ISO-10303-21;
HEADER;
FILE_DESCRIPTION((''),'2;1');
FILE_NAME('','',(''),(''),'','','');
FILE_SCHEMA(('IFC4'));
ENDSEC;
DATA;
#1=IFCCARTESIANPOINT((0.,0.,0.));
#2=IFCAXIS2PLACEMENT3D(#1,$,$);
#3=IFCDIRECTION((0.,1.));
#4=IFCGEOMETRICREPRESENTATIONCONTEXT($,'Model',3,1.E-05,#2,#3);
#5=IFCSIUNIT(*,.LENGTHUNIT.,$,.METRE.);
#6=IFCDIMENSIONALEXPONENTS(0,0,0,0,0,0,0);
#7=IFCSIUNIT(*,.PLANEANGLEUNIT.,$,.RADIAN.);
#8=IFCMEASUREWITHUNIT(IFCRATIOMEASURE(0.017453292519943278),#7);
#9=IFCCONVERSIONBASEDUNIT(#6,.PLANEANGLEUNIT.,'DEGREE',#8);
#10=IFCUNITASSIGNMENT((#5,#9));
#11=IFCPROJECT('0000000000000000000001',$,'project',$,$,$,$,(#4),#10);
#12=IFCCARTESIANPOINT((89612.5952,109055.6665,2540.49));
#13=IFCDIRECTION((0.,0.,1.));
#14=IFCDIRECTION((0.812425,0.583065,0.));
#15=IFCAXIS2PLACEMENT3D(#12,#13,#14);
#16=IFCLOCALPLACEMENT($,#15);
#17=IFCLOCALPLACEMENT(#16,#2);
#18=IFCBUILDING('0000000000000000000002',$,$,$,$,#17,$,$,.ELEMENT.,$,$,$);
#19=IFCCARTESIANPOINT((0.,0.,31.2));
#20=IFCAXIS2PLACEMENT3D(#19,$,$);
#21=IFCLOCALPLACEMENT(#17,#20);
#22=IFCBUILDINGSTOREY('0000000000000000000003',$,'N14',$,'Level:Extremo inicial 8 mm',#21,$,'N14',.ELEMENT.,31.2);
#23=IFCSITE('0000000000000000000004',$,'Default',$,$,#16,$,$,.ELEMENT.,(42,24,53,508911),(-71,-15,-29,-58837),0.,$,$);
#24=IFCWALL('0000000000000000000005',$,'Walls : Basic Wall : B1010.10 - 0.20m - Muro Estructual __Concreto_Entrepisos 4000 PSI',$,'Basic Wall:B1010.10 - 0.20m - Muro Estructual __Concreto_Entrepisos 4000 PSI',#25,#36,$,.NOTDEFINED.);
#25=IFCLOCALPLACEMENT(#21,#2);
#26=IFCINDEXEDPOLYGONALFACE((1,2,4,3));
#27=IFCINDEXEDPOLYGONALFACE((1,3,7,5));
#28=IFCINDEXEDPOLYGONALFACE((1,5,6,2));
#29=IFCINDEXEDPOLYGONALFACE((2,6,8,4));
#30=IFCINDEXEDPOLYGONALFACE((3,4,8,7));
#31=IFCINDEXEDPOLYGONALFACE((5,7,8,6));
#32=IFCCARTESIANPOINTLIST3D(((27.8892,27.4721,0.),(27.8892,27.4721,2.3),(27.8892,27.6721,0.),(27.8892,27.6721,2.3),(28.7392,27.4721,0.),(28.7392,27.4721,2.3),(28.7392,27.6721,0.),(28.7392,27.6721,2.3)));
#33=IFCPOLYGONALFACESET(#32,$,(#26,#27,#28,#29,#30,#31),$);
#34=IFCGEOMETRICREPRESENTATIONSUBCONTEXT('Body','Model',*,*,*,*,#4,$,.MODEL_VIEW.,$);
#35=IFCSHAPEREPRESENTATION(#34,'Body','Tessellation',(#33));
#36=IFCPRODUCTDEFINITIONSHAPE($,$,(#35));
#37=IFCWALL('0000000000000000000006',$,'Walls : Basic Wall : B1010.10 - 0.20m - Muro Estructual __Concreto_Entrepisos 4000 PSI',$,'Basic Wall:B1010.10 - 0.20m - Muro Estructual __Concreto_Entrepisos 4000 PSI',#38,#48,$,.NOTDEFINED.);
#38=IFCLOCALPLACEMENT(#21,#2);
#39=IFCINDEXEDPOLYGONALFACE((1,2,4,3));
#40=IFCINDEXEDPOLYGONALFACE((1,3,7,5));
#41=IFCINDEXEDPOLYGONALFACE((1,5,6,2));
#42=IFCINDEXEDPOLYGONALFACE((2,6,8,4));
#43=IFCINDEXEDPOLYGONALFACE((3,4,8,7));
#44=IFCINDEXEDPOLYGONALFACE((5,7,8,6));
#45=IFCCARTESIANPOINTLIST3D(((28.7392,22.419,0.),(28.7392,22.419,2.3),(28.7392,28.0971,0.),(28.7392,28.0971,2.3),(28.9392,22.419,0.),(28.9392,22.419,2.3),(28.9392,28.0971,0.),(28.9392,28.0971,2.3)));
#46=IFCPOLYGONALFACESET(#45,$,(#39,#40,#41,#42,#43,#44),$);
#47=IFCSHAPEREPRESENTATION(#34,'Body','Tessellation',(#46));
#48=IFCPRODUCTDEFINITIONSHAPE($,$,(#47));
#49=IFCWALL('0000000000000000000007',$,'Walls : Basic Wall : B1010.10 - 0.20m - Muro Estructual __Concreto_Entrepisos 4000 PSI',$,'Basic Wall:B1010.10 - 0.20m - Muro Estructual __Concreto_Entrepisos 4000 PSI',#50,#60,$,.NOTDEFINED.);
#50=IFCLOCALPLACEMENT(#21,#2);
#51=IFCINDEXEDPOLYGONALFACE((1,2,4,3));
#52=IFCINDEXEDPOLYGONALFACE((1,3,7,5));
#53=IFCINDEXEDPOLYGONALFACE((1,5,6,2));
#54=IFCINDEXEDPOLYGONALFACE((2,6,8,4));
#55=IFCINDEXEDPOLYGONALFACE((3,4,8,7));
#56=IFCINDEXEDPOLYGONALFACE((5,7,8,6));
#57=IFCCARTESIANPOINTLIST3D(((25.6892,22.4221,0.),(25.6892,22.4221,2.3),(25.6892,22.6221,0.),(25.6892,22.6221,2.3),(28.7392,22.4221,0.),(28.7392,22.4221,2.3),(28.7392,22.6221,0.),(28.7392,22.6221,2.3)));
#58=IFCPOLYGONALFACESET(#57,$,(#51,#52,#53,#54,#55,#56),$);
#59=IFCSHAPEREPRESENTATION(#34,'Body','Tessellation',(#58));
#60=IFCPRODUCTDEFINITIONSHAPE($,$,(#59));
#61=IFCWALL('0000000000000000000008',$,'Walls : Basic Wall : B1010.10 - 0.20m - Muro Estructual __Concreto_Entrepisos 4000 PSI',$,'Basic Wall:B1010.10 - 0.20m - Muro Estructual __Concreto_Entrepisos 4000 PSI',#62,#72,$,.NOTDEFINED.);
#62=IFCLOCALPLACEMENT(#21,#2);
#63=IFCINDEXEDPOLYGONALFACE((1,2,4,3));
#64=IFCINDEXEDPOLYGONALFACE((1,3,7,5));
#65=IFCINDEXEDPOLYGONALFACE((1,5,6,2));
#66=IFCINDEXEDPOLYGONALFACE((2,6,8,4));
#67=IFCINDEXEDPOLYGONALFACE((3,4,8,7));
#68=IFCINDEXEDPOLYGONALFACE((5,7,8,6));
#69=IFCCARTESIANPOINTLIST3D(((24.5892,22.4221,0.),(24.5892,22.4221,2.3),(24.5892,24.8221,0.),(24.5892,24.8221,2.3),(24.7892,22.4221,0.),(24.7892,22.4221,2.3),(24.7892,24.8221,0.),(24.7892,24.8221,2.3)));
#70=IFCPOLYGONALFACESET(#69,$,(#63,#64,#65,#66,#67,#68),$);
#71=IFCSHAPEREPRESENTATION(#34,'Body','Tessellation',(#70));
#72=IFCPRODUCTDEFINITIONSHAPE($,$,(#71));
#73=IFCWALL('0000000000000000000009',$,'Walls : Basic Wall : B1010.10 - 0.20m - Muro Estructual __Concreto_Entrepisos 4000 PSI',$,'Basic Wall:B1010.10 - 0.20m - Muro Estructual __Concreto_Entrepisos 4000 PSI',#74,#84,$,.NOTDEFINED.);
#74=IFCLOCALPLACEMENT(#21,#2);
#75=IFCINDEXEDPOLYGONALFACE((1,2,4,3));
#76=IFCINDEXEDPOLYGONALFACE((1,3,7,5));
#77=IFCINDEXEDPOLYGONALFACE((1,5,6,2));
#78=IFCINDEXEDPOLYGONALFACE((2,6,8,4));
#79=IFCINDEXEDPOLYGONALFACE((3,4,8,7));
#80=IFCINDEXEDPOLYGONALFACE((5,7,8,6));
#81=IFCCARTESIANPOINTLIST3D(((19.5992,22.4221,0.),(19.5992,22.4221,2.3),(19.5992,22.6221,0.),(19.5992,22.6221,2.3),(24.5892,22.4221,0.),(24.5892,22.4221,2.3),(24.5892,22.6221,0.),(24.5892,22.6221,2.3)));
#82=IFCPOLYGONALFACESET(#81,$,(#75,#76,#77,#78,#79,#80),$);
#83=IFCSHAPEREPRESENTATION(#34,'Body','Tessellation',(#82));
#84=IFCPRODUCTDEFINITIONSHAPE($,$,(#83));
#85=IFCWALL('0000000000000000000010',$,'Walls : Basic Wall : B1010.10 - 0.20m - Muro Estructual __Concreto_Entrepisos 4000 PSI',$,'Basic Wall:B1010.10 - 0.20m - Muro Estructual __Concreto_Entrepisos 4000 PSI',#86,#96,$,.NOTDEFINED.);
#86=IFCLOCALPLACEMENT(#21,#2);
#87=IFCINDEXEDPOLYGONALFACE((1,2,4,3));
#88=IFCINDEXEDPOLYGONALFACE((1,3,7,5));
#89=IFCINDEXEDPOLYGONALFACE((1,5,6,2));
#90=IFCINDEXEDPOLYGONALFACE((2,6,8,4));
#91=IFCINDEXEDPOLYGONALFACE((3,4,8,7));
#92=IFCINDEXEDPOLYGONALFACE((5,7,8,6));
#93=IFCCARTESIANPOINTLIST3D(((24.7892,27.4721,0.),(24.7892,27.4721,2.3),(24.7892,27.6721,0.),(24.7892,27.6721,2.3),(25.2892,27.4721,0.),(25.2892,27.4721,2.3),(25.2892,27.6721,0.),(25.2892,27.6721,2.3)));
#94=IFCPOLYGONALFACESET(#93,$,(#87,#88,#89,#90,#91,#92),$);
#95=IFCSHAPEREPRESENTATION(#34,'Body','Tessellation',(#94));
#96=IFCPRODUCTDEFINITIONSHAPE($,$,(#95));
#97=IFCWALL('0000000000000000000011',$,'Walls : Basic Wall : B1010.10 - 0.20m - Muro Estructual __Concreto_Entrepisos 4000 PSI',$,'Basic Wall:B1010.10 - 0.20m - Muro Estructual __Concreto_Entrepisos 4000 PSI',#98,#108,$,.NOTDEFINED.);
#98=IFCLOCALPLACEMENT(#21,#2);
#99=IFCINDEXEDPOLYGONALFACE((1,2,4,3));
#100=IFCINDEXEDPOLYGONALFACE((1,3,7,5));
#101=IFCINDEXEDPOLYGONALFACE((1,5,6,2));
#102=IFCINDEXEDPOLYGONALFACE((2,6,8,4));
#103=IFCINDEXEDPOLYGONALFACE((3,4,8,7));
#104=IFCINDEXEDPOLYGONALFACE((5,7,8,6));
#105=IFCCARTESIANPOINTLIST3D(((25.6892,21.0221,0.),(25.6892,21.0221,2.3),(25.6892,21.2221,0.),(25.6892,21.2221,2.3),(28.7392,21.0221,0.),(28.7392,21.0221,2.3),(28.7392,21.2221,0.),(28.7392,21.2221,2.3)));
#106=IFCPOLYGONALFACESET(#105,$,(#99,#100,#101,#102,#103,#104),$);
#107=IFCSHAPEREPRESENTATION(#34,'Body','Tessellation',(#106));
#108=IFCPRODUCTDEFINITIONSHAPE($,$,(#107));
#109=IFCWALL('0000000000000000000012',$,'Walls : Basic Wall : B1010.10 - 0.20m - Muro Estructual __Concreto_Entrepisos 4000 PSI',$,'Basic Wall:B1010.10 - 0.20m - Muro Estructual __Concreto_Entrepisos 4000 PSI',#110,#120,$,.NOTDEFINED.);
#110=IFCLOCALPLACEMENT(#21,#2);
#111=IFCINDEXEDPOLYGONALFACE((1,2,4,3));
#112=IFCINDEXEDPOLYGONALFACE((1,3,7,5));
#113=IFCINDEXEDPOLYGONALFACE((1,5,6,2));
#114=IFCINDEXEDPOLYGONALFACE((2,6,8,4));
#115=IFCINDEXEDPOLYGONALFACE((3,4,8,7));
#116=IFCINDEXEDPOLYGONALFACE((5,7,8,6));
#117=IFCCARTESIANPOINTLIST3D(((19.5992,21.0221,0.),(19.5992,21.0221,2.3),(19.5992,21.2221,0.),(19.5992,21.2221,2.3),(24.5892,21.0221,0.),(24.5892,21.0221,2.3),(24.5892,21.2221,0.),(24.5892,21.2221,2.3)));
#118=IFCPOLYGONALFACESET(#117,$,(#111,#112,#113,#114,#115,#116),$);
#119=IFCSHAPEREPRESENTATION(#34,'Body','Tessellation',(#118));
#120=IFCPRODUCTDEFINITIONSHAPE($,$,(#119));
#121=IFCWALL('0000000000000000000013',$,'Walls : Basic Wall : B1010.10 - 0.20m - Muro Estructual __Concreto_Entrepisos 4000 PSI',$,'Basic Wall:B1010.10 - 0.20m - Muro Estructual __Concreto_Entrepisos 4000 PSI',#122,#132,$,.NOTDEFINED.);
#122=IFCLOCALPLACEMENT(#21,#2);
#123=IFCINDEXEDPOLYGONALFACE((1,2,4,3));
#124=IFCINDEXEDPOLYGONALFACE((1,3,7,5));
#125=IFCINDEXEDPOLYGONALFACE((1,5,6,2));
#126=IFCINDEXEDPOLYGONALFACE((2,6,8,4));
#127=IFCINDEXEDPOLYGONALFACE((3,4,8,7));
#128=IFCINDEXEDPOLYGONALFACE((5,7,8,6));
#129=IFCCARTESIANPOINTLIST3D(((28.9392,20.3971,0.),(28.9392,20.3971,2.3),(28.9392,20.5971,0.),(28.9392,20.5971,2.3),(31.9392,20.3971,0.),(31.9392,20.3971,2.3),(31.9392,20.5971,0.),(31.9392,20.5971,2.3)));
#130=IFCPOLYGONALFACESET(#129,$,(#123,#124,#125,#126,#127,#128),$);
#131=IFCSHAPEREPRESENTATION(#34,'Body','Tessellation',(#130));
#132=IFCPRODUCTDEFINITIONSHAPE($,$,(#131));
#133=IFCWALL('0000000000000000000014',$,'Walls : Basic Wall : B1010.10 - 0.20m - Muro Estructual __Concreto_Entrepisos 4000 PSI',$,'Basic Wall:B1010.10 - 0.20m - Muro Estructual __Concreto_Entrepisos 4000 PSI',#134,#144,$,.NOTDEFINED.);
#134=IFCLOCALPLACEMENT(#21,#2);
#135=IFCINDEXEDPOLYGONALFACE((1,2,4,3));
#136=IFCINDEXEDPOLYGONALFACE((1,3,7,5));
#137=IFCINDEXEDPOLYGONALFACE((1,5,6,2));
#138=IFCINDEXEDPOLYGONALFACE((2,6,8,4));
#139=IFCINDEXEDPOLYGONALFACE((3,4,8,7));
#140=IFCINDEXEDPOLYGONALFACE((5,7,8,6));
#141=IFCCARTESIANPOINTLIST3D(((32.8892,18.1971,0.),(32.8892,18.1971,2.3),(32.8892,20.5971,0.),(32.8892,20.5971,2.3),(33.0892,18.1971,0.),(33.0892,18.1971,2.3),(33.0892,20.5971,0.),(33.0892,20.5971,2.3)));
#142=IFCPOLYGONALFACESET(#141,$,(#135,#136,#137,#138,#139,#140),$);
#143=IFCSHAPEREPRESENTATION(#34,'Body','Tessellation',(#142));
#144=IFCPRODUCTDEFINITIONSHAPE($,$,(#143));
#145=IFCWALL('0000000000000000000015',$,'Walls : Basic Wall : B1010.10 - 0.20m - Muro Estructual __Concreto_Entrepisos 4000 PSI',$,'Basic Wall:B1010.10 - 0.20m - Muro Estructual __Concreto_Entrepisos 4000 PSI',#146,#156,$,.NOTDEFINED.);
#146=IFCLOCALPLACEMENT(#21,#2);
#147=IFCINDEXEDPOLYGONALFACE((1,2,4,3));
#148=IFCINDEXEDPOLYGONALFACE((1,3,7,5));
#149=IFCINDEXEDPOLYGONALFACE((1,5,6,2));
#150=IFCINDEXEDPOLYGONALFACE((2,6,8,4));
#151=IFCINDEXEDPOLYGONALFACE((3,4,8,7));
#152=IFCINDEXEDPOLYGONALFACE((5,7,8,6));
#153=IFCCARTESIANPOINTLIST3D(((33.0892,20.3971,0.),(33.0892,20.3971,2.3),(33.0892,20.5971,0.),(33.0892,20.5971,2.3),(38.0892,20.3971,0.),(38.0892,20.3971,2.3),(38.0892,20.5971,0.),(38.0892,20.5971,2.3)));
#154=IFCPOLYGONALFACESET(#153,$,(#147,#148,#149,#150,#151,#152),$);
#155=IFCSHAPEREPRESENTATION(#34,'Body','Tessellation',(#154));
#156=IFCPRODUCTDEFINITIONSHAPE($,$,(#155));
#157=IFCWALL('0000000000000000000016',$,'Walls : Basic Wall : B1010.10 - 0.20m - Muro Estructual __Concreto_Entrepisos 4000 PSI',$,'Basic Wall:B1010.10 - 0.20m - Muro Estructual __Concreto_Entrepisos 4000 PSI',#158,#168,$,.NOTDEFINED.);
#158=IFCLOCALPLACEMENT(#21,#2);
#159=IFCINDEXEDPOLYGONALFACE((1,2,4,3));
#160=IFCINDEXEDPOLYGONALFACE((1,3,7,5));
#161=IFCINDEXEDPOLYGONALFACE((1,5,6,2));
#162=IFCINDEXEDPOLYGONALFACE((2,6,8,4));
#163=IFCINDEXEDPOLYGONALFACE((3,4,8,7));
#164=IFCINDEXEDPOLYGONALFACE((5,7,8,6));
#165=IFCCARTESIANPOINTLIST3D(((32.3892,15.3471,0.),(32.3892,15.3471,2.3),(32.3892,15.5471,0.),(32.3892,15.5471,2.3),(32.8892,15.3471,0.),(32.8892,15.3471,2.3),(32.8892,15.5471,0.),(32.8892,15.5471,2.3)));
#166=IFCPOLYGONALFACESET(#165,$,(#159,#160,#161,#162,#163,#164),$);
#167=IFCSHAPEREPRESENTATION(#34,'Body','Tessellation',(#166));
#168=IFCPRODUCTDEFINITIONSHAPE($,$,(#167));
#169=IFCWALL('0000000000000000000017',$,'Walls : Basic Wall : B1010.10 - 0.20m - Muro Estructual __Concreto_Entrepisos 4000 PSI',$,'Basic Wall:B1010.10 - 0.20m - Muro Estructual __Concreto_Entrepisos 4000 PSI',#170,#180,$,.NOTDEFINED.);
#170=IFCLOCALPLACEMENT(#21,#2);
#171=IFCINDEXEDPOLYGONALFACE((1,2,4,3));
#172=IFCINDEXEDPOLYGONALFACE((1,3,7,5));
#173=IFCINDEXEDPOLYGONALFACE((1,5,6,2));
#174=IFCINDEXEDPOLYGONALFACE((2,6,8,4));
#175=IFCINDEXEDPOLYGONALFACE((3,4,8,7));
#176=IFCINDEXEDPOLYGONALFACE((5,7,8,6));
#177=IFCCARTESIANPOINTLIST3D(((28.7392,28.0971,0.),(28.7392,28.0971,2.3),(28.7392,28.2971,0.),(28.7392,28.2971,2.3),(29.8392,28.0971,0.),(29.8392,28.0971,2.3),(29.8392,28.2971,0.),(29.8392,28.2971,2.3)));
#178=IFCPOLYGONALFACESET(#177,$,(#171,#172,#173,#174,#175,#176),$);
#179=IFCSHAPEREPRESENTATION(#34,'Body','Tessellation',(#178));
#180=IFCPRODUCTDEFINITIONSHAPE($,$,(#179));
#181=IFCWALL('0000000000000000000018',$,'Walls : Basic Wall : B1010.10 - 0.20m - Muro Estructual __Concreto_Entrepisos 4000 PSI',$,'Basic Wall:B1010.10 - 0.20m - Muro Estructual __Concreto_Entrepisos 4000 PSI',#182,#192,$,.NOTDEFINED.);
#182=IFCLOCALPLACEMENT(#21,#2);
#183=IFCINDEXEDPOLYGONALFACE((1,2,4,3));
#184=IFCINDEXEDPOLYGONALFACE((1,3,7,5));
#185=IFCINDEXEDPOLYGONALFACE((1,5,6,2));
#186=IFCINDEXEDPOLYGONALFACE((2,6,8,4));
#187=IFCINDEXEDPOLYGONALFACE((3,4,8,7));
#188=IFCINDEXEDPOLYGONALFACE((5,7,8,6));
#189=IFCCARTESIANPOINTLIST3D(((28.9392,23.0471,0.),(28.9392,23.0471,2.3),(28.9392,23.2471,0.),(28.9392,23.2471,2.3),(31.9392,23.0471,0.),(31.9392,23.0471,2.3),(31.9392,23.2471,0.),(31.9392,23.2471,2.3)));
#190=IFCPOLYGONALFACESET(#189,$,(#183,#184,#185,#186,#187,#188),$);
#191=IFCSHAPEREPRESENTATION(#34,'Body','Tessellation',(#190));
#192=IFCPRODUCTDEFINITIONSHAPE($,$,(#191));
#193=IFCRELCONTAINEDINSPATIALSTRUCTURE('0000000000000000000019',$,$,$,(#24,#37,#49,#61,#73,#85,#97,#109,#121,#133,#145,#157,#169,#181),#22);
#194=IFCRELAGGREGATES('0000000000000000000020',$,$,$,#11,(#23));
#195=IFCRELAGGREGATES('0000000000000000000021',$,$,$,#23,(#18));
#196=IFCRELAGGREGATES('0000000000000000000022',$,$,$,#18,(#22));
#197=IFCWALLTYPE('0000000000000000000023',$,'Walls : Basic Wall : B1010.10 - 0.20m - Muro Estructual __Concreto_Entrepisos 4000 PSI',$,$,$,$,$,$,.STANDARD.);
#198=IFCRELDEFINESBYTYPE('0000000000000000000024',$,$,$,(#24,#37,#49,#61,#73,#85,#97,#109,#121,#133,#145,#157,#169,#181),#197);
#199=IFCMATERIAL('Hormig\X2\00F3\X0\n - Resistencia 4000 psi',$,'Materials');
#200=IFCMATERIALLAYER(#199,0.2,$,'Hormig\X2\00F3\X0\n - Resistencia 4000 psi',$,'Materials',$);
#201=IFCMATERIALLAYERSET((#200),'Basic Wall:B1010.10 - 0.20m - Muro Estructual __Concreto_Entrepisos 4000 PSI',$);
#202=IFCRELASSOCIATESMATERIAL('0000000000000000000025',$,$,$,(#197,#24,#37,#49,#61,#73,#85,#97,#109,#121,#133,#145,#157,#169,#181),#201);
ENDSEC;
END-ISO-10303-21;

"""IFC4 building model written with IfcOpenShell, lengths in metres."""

from ifc_helpers import new_model, entity, si_unit, converted_unit, direction, frame, frame_2d, origin, place, context, subcontext, project, spatial, rectangle, extrude, material, layer, layer_set, layer_usage, type_object, element, save


model = new_model("IFC4")

# Units and contexts
model_context = context("Model", 3, precision=1e-05, world=origin(), true_north=direction((0.0, 1.0)))
body_context = subcontext(model_context, "Body", "Model", "MODEL_VIEW")
ifc_project = project(units=[si_unit("LENGTHUNIT", "METRE"), converted_unit("PLANEANGLEUNIT", "DEGREE", entity("IfcRatioMeasure", 0.017453292519943278), si_unit("PLANEANGLEUNIT", "RADIAN"), dimensions=[0, 0, 0, 0, 0, 0, 0])], contexts=[model_context])

# Site, building, storey
site_placement = place(None, frame((89612.5952, 109055.6665, 2540.49), z_axis=(0.0, 0.0, 1.0), x_axis=(0.812425, 0.583065, 0.0)))
site = spatial("IfcSite", under=ifc_project, at=site_placement, Name="Default", CompositionType="ELEMENT", RefLatitude=(42, 24, 53, 508911), RefLongitude=(-71, -15, -29, -58837), RefElevation=0.0)
building_placement = place(site_placement, origin())
building = spatial("IfcBuilding", under=site, at=building_placement, CompositionType="ELEMENT")
storey_placement = place(building_placement, frame((0.0, 0.0, 31.2)))
storey = spatial("IfcBuildingStorey", under=building, at=storey_placement, Name="N14", ObjectType="Level:Extremo inicial 8 mm", LongName="N14", CompositionType="ELEMENT", Elevation=31.2)

# Walls
ifc_material = material(Name="Hormigón - Resistencia 4000 psi", Category="Materials")
ifc_layer_1 = layer(ifc_material, 0.2, Name="Hormigón - Resistencia 4000 psi", Category="Materials")
ifc_layer_set_1 = layer_set([ifc_layer_1], Name="Basic Wall:B1010.10 - 0.20m - Muro Estructual __Concreto_Entrepisos 4000 PSI")
ifc_layer_usage_1 = layer_usage(ifc_layer_set_1, "AXIS2", "NEGATIVE", 0.1)
wall_type_1 = type_object("IfcWallType", Name="Walls : Basic Wall : B1010.10 - 0.20m - Muro Estructual __Concreto_Entrepisos 4000 PSI", PredefinedType="STANDARD", material=ifc_layer_set_1)
wall_1_placement = place(storey_placement, frame((27.8892, 27.5721, 0.0)))
element("IfcWall", 1, at=wall_1_placement, inside=storey, type_object=wall_type_1, material=ifc_layer_usage_1, Name="Walls : Basic Wall : B1010.10 - 0.20m - Muro Estructual __Concreto_Entrepisos 4000 PSI", ObjectType="Basic Wall:B1010.10 - 0.20m - Muro Estructual __Concreto_Entrepisos 4000 PSI", PredefinedType="NOTDEFINED", context=body_context, shape_type="SweptSolid", body=[
    extrude(rectangle(XDim=0.85, YDim=0.2, at=frame_2d((0.425, 0.0), x_axis=(-1.0, 0.0))), origin(), (0.0, 0.0, 1.0), 2.3),
])
ifc_layer_usage_2 = layer_usage(ifc_layer_set_1, "AXIS2", "NEGATIVE", 0.1)
wall_2_placement = place(storey_placement, frame((28.8392, 28.0971, 0.0), z_axis=(0.0, 0.0, 1.0), x_axis=(0.0, -1.0, 0.0)))
element("IfcWall", 2, at=wall_2_placement, inside=storey, type_object=wall_type_1, material=ifc_layer_usage_2, Name="Walls : Basic Wall : B1010.10 - 0.20m - Muro Estructual __Concreto_Entrepisos 4000 PSI", ObjectType="Basic Wall:B1010.10 - 0.20m - Muro Estructual __Concreto_Entrepisos 4000 PSI", PredefinedType="NOTDEFINED", context=body_context, shape_type="SweptSolid", body=[
    extrude(rectangle(XDim=5.6781, YDim=0.2, at=frame_2d((2.839, 0.0), x_axis=(-1.0, 0.0))), origin(), (0.0, 0.0, 1.0), 2.3),
])
ifc_layer_usage_3 = layer_usage(ifc_layer_set_1, "AXIS2", "NEGATIVE", 0.1)
wall_3_placement = place(storey_placement, frame((28.7392, 22.5221, 0.0), z_axis=(0.0, 0.0, 1.0), x_axis=(-1.0, 0.0, 0.0)))
element("IfcWall", 3, at=wall_3_placement, inside=storey, type_object=wall_type_1, material=ifc_layer_usage_3, Name="Walls : Basic Wall : B1010.10 - 0.20m - Muro Estructual __Concreto_Entrepisos 4000 PSI", ObjectType="Basic Wall:B1010.10 - 0.20m - Muro Estructual __Concreto_Entrepisos 4000 PSI", PredefinedType="NOTDEFINED", context=body_context, shape_type="SweptSolid", body=[
    extrude(rectangle(XDim=3.05, YDim=0.2, at=frame_2d((1.525, 0.0), x_axis=(-1.0, 0.0))), origin(), (0.0, 0.0, 1.0), 2.3),
])
ifc_layer_usage_4 = layer_usage(ifc_layer_set_1, "AXIS2", "NEGATIVE", 0.1)
wall_4_placement = place(storey_placement, frame((24.6892, 24.8221, 0.0), z_axis=(0.0, 0.0, 1.0), x_axis=(0.0, -1.0, 0.0)))
element("IfcWall", 4, at=wall_4_placement, inside=storey, type_object=wall_type_1, material=ifc_layer_usage_4, Name="Walls : Basic Wall : B1010.10 - 0.20m - Muro Estructual __Concreto_Entrepisos 4000 PSI", ObjectType="Basic Wall:B1010.10 - 0.20m - Muro Estructual __Concreto_Entrepisos 4000 PSI", PredefinedType="NOTDEFINED", context=body_context, shape_type="SweptSolid", body=[
    extrude(rectangle(XDim=2.4, YDim=0.2, at=frame_2d((1.2, 0.0), x_axis=(-1.0, 0.0))), origin(), (0.0, 0.0, 1.0), 2.3),
])
ifc_layer_usage_5 = layer_usage(ifc_layer_set_1, "AXIS2", "NEGATIVE", 0.1)
wall_5_placement = place(storey_placement, frame((24.5892, 22.5221, 0.0), z_axis=(0.0, 0.0, 1.0), x_axis=(-1.0, 0.0, 0.0)))
element("IfcWall", 5, at=wall_5_placement, inside=storey, type_object=wall_type_1, material=ifc_layer_usage_5, Name="Walls : Basic Wall : B1010.10 - 0.20m - Muro Estructual __Concreto_Entrepisos 4000 PSI", ObjectType="Basic Wall:B1010.10 - 0.20m - Muro Estructual __Concreto_Entrepisos 4000 PSI", PredefinedType="NOTDEFINED", context=body_context, shape_type="SweptSolid", body=[
    extrude(rectangle(XDim=4.99, YDim=0.2, at=frame_2d((2.495, 0.0), x_axis=(-1.0, 0.0))), origin(), (0.0, 0.0, 1.0), 2.3),
])
ifc_layer_usage_6 = layer_usage(ifc_layer_set_1, "AXIS2", "NEGATIVE", 0.1)
wall_6_placement = place(storey_placement, frame((25.2892, 27.5721, 0.0), z_axis=(0.0, 0.0, 1.0), x_axis=(-1.0, 0.0, 0.0)))
element("IfcWall", 6, at=wall_6_placement, inside=storey, type_object=wall_type_1, material=ifc_layer_usage_6, Name="Walls : Basic Wall : B1010.10 - 0.20m - Muro Estructual __Concreto_Entrepisos 4000 PSI", ObjectType="Basic Wall:B1010.10 - 0.20m - Muro Estructual __Concreto_Entrepisos 4000 PSI", PredefinedType="NOTDEFINED", context=body_context, shape_type="SweptSolid", body=[
    extrude(rectangle(XDim=0.5, YDim=0.2, at=frame_2d((0.25, 0.0), x_axis=(-1.0, 0.0))), origin(), (0.0, 0.0, 1.0), 2.3),
])
ifc_layer_usage_7 = layer_usage(ifc_layer_set_1, "AXIS2", "POSITIVE", -0.1)
wall_7_placement = place(storey_placement, frame((28.7392, 21.1221, 0.0), z_axis=(0.0, 0.0, 1.0), x_axis=(-1.0, 0.0, 0.0)))
element("IfcWall", 7, at=wall_7_placement, inside=storey, type_object=wall_type_1, material=ifc_layer_usage_7, Name="Walls : Basic Wall : B1010.10 - 0.20m - Muro Estructual __Concreto_Entrepisos 4000 PSI", ObjectType="Basic Wall:B1010.10 - 0.20m - Muro Estructual __Concreto_Entrepisos 4000 PSI", PredefinedType="NOTDEFINED", context=body_context, shape_type="SweptSolid", body=[
    extrude(rectangle(XDim=3.05, YDim=0.2, at=frame_2d((1.525, 0.0), x_axis=(-1.0, 0.0))), origin(), (0.0, 0.0, 1.0), 2.3),
])
ifc_layer_usage_8 = layer_usage(ifc_layer_set_1, "AXIS2", "POSITIVE", -0.1)
wall_8_placement = place(storey_placement, frame((24.5892, 21.1221, 0.0), z_axis=(0.0, 0.0, 1.0), x_axis=(-1.0, 0.0, 0.0)))
element("IfcWall", 8, at=wall_8_placement, inside=storey, type_object=wall_type_1, material=ifc_layer_usage_8, Name="Walls : Basic Wall : B1010.10 - 0.20m - Muro Estructual __Concreto_Entrepisos 4000 PSI", ObjectType="Basic Wall:B1010.10 - 0.20m - Muro Estructual __Concreto_Entrepisos 4000 PSI", PredefinedType="NOTDEFINED", context=body_context, shape_type="SweptSolid", body=[
    extrude(rectangle(XDim=4.99, YDim=0.2, at=frame_2d((2.495, 0.0), x_axis=(-1.0, 0.0))), origin(), (0.0, 0.0, 1.0), 2.3),
])
ifc_layer_usage_9 = layer_usage(ifc_layer_set_1, "AXIS2", "NEGATIVE", 0.1)
wall_9_placement = place(storey_placement, frame((28.9392, 20.4971, 0.0)))
element("IfcWall", 9, at=wall_9_placement, inside=storey, type_object=wall_type_1, material=ifc_layer_usage_9, Name="Walls : Basic Wall : B1010.10 - 0.20m - Muro Estructual __Concreto_Entrepisos 4000 PSI", ObjectType="Basic Wall:B1010.10 - 0.20m - Muro Estructual __Concreto_Entrepisos 4000 PSI", PredefinedType="NOTDEFINED", context=body_context, shape_type="SweptSolid", body=[
    extrude(rectangle(XDim=3.0, YDim=0.2, at=frame_2d((1.5, 0.0), x_axis=(-1.0, 0.0))), origin(), (0.0, 0.0, 1.0), 2.3),
])
ifc_layer_usage_10 = layer_usage(ifc_layer_set_1, "AXIS2", "NEGATIVE", 0.1)
wall_10_placement = place(storey_placement, frame((32.9892, 18.1971, 0.0), z_axis=(0.0, 0.0, 1.0), x_axis=(0.0, 1.0, 0.0)))
element("IfcWall", 10, at=wall_10_placement, inside=storey, type_object=wall_type_1, material=ifc_layer_usage_10, Name="Walls : Basic Wall : B1010.10 - 0.20m - Muro Estructual __Concreto_Entrepisos 4000 PSI", ObjectType="Basic Wall:B1010.10 - 0.20m - Muro Estructual __Concreto_Entrepisos 4000 PSI", PredefinedType="NOTDEFINED", context=body_context, shape_type="SweptSolid", body=[
    extrude(rectangle(XDim=2.4, YDim=0.2, at=frame_2d((1.2, 0.0), x_axis=(-1.0, 0.0))), origin(), (0.0, 0.0, 1.0), 2.3),
])
ifc_layer_usage_11 = layer_usage(ifc_layer_set_1, "AXIS2", "NEGATIVE", 0.1)
wall_11_placement = place(storey_placement, frame((33.0892, 20.4971, 0.0)))
element("IfcWall", 11, at=wall_11_placement, inside=storey, type_object=wall_type_1, material=ifc_layer_usage_11, Name="Walls : Basic Wall : B1010.10 - 0.20m - Muro Estructual __Concreto_Entrepisos 4000 PSI", ObjectType="Basic Wall:B1010.10 - 0.20m - Muro Estructual __Concreto_Entrepisos 4000 PSI", PredefinedType="NOTDEFINED", context=body_context, shape_type="SweptSolid", body=[
    extrude(rectangle(XDim=5.0, YDim=0.2, at=frame_2d((2.5, 0.0), x_axis=(-1.0, 0.0))), origin(), (0.0, 0.0, 1.0), 2.3),
])
ifc_layer_usage_12 = layer_usage(ifc_layer_set_1, "AXIS2", "NEGATIVE", 0.1)
wall_12_placement = place(storey_placement, frame((32.3892, 15.4471, 0.0)))
element("IfcWall", 12, at=wall_12_placement, inside=storey, type_object=wall_type_1, material=ifc_layer_usage_12, Name="Walls : Basic Wall : B1010.10 - 0.20m - Muro Estructual __Concreto_Entrepisos 4000 PSI", ObjectType="Basic Wall:B1010.10 - 0.20m - Muro Estructual __Concreto_Entrepisos 4000 PSI", PredefinedType="NOTDEFINED", context=body_context, shape_type="SweptSolid", body=[
    extrude(rectangle(XDim=0.5, YDim=0.2, at=frame_2d((0.25, 0.0), x_axis=(-1.0, 0.0))), origin(), (0.0, 0.0, 1.0), 2.3),
])
ifc_layer_usage_13 = layer_usage(ifc_layer_set_1, "AXIS2", "POSITIVE", -0.1)
wall_13_placement = place(storey_placement, frame((29.8392, 28.1971, 0.0), z_axis=(0.0, 0.0, 1.0), x_axis=(-1.0, 0.0, 0.0)))
element("IfcWall", 13, at=wall_13_placement, inside=storey, type_object=wall_type_1, material=ifc_layer_usage_13, Name="Walls : Basic Wall : B1010.10 - 0.20m - Muro Estructual __Concreto_Entrepisos 4000 PSI", ObjectType="Basic Wall:B1010.10 - 0.20m - Muro Estructual __Concreto_Entrepisos 4000 PSI", PredefinedType="NOTDEFINED", context=body_context, shape_type="SweptSolid", body=[
    extrude(rectangle(XDim=1.1, YDim=0.2, at=frame_2d((0.55, 0.0), x_axis=(-1.0, 0.0))), origin(), (0.0, 0.0, 1.0), 2.3),
])
ifc_layer_usage_14 = layer_usage(ifc_layer_set_1, "AXIS2", "POSITIVE", -0.1)
wall_14_placement = place(storey_placement, frame((28.9392, 23.1471, 0.0)))
element("IfcWall", 14, at=wall_14_placement, inside=storey, type_object=wall_type_1, material=ifc_layer_usage_14, Name="Walls : Basic Wall : B1010.10 - 0.20m - Muro Estructual __Concreto_Entrepisos 4000 PSI", ObjectType="Basic Wall:B1010.10 - 0.20m - Muro Estructual __Concreto_Entrepisos 4000 PSI", PredefinedType="NOTDEFINED", context=body_context, shape_type="SweptSolid", body=[
    extrude(rectangle(XDim=3.0, YDim=0.2, at=frame_2d((1.5, 0.0), x_axis=(-1.0, 0.0))), origin(), (0.0, 0.0, 1.0), 2.3),
])

save(model, "model.ifc")
